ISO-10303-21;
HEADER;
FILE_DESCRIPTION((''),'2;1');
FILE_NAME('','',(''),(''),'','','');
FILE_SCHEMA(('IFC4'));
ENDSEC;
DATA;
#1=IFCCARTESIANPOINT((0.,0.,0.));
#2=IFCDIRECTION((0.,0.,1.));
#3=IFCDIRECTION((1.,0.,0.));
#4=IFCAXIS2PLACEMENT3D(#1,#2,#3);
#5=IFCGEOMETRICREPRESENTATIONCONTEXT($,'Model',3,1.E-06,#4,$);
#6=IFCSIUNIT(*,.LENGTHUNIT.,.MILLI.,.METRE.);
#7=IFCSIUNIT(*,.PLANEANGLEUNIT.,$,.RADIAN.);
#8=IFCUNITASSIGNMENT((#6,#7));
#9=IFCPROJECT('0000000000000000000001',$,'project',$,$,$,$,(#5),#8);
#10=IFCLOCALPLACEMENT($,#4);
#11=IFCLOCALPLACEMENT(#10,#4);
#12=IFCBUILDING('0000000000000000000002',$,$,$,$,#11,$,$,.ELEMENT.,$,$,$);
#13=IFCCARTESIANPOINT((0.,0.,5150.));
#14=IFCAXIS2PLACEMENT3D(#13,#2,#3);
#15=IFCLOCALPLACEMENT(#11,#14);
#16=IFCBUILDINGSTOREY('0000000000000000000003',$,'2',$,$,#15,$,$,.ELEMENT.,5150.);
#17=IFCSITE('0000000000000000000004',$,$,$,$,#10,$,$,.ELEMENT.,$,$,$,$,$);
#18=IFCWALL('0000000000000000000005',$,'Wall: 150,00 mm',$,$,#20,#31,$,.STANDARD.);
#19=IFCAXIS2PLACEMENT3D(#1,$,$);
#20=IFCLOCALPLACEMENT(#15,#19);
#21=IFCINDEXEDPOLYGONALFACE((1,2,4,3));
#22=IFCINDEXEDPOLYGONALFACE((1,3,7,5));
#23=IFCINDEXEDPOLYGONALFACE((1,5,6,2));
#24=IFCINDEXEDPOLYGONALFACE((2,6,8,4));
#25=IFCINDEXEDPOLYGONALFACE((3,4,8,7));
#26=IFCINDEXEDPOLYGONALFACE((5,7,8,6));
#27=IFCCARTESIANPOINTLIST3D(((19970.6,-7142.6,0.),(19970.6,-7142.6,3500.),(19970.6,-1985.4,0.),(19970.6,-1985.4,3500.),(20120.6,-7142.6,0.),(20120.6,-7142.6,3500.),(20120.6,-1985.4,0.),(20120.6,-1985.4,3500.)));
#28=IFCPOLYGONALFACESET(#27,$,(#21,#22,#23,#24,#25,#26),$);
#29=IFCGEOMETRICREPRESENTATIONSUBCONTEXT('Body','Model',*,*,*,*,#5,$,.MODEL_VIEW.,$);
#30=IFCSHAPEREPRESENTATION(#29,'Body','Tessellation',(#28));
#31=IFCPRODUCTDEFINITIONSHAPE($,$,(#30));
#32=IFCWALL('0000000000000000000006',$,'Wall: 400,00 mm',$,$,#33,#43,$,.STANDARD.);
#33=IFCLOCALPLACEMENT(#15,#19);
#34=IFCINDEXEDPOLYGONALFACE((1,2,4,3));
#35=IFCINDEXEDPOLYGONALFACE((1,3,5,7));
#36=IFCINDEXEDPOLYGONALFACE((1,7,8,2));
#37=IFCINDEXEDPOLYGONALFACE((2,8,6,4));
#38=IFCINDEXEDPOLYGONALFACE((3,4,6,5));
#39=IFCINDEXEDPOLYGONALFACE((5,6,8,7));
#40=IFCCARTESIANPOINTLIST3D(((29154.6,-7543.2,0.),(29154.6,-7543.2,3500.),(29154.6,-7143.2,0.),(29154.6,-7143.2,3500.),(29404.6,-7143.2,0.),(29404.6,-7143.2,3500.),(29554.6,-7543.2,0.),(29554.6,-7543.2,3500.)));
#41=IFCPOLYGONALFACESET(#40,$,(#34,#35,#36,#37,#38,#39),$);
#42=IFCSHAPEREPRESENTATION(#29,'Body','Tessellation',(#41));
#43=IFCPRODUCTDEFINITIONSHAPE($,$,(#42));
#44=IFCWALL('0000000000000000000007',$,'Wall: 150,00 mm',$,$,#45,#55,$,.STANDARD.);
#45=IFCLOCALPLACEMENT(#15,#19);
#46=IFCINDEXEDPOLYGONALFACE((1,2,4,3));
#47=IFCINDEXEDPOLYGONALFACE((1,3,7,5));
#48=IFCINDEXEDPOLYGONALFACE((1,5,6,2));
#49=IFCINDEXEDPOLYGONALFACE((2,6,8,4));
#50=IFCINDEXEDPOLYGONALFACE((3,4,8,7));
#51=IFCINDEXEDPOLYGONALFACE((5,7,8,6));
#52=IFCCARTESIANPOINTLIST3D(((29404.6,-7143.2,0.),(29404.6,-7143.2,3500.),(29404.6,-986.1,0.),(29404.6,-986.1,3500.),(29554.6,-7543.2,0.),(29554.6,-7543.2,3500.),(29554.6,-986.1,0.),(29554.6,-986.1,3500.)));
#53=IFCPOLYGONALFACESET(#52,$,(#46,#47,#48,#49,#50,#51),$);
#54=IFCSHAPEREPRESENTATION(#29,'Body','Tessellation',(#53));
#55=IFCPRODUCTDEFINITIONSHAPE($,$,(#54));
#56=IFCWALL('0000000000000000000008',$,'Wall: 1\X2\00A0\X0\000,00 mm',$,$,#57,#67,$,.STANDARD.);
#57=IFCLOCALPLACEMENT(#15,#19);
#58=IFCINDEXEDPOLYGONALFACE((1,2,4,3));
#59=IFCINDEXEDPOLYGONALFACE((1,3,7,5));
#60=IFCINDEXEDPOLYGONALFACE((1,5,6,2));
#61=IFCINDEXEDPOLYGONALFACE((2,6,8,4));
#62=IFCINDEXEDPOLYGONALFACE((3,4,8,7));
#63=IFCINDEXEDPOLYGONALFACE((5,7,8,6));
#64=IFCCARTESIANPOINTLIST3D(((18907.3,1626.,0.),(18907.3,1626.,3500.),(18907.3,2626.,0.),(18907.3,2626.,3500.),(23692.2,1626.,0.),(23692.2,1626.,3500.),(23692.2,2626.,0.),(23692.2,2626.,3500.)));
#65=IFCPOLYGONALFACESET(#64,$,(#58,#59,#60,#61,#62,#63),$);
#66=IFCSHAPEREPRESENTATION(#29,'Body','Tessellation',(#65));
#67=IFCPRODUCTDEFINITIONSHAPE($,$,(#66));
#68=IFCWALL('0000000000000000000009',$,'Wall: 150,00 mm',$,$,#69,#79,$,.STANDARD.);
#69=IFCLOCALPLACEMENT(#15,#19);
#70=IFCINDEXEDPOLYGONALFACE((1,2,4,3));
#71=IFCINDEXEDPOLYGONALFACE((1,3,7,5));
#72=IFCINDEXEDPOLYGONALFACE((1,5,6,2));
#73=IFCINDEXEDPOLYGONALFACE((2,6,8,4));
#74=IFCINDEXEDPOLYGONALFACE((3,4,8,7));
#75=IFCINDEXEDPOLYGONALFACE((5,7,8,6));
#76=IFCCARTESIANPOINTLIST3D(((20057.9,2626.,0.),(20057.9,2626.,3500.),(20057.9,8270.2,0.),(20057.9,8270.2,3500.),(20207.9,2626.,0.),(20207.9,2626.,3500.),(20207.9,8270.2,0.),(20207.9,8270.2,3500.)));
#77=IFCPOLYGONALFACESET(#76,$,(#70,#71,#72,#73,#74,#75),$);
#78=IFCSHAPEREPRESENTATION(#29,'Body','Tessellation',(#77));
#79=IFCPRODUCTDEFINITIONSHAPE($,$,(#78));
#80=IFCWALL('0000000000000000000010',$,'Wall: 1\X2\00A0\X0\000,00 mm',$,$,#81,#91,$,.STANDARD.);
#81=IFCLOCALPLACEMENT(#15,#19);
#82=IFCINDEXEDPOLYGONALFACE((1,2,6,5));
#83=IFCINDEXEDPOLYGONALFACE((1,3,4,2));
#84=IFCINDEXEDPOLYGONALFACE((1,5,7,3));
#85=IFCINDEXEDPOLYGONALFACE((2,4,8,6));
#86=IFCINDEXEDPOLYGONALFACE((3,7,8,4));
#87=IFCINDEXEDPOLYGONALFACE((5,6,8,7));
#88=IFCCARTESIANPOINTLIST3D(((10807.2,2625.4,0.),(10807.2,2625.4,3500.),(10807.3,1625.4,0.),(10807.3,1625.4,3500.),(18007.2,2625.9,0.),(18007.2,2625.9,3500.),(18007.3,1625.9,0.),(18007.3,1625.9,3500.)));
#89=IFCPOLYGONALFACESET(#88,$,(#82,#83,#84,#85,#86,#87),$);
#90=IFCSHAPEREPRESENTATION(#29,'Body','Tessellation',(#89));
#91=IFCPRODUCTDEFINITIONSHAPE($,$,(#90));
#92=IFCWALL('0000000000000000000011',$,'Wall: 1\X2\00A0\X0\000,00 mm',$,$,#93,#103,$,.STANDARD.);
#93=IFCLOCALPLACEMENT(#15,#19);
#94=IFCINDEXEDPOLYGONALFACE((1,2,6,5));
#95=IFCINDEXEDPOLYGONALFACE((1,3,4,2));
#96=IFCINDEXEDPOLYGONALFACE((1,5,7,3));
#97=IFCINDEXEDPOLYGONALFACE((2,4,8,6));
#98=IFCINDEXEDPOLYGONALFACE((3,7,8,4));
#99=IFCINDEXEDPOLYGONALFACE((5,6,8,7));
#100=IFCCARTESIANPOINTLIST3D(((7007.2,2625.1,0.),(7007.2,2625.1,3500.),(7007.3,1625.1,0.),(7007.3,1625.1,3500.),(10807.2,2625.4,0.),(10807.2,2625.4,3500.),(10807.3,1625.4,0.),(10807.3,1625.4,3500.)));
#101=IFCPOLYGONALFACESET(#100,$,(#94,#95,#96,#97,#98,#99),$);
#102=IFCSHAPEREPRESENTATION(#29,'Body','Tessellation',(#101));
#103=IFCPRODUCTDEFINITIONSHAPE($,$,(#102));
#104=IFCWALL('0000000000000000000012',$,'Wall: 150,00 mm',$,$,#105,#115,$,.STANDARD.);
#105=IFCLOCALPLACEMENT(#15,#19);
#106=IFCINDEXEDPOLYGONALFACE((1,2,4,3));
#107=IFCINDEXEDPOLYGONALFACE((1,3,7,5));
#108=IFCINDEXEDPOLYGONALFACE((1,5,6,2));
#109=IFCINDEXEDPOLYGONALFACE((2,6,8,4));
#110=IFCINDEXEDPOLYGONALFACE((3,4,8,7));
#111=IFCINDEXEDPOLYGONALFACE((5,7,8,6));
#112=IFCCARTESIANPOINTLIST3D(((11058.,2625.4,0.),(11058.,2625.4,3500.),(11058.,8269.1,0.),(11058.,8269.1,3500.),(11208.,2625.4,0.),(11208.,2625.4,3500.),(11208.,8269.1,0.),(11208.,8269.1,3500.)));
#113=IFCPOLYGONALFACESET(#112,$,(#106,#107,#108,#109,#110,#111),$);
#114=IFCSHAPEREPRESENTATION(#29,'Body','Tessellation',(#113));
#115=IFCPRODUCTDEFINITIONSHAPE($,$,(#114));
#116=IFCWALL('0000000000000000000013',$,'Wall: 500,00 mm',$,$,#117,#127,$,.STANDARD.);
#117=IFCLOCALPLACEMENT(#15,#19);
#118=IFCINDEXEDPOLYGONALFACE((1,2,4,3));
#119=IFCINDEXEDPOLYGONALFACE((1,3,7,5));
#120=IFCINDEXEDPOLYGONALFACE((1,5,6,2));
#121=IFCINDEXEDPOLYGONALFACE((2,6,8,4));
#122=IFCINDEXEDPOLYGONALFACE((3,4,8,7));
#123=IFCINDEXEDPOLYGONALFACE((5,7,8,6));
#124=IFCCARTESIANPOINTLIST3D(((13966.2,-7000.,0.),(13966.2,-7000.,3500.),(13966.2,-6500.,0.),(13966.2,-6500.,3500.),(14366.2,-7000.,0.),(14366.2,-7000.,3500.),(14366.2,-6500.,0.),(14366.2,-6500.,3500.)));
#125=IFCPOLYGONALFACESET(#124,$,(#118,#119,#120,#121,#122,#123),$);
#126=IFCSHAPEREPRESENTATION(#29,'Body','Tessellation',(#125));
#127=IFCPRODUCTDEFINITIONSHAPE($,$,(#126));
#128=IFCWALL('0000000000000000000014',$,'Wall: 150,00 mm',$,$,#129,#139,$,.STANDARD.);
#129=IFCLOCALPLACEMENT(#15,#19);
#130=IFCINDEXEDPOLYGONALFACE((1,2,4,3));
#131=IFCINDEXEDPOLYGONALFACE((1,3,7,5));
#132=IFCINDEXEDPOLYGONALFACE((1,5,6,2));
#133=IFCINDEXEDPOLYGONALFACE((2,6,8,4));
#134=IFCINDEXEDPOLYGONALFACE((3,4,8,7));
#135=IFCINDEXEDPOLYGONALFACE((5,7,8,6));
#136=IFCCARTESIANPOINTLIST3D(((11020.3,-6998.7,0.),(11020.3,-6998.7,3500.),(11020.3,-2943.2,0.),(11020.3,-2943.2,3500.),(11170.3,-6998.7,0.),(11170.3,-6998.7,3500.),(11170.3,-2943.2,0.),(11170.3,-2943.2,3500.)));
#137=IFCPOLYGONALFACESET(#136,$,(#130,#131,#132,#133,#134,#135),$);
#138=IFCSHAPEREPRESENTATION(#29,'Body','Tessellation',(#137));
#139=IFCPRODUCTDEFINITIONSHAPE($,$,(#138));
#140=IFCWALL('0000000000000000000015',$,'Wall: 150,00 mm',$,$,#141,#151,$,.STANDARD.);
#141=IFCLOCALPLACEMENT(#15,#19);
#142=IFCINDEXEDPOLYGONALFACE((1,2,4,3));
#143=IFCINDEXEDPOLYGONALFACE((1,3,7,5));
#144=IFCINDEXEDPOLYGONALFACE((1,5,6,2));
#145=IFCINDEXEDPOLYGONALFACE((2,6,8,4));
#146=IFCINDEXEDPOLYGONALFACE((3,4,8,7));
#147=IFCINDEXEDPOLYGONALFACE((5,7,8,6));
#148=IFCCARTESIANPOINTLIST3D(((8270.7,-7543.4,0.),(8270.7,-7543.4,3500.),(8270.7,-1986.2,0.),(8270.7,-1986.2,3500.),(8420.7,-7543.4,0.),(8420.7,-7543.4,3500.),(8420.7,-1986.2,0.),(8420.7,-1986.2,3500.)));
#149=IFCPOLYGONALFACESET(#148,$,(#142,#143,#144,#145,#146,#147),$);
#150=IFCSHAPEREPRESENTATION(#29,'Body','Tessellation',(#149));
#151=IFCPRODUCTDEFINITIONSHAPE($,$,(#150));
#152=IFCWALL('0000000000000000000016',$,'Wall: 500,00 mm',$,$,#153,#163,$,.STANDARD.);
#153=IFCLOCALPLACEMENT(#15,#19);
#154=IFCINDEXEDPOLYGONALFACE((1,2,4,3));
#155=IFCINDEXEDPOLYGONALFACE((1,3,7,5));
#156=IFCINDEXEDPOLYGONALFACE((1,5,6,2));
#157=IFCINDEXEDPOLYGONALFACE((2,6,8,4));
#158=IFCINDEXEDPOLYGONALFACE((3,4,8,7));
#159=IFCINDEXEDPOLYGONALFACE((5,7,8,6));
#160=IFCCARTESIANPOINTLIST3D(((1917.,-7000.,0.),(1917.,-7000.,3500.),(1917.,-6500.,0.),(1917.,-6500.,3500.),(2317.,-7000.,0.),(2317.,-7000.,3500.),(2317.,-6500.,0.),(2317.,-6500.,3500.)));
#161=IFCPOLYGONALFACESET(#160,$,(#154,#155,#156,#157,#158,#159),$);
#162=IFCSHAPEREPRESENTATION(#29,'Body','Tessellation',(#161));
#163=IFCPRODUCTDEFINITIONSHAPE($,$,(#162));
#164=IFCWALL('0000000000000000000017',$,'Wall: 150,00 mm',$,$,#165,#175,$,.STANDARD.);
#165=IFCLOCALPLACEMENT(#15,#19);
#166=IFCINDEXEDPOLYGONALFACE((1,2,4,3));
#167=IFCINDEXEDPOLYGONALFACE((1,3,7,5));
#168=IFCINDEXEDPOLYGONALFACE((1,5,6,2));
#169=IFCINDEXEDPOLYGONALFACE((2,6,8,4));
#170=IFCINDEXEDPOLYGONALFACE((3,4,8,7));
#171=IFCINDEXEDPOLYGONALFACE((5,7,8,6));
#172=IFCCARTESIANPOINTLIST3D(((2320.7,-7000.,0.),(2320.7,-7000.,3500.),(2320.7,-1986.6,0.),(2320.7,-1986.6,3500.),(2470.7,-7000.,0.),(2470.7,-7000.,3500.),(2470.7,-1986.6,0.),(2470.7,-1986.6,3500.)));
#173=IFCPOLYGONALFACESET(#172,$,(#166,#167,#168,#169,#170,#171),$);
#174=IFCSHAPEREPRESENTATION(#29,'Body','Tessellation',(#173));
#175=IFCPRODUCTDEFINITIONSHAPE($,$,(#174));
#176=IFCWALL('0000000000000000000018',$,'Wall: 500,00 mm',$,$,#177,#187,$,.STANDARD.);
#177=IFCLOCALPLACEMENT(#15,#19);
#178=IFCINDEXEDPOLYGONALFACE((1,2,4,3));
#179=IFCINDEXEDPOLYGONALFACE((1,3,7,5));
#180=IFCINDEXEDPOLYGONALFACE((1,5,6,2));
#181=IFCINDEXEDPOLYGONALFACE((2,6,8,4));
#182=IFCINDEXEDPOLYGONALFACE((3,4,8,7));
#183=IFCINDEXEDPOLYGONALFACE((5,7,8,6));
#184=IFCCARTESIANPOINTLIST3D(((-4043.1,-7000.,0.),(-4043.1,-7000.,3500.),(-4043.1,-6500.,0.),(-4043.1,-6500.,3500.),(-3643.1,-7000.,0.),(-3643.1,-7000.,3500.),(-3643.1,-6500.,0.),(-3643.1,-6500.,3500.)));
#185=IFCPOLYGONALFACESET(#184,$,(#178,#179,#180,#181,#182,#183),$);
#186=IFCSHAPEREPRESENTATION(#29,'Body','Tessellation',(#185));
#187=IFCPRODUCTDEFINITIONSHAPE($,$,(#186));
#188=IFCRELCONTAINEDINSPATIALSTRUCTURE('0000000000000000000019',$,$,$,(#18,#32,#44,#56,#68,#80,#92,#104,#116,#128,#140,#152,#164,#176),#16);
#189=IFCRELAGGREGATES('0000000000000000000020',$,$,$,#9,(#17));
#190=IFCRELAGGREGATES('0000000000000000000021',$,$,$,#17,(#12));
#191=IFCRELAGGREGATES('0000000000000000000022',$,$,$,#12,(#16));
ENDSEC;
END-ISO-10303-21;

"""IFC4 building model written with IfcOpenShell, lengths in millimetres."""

from ifc_helpers import new_model, si_unit, frame, origin_with_axes, place, context, subcontext, project, spatial, line, indexed_curve, outline, extrude, element, save


model = new_model("IFC4")

# Units and contexts
model_context = context("Model", 3, precision=1e-06, world=origin_with_axes())
body_context = subcontext(model_context, "Body", "Model", "MODEL_VIEW")
ifc_project = project(units=[si_unit("LENGTHUNIT", "METRE", prefix="MILLI"), si_unit("PLANEANGLEUNIT", "RADIAN")], contexts=[model_context])

# Site, building, storey
site_placement = place(None, origin_with_axes())
site = spatial("IfcSite", under=ifc_project, at=site_placement, CompositionType="ELEMENT")
building_placement = place(site_placement, origin_with_axes())
building = spatial("IfcBuilding", under=site, at=building_placement, CompositionType="ELEMENT")
storey_placement = place(building_placement, frame((0.0, 0.0, 5150.0), z_axis=(0.0, 0.0, 1.0), x_axis=(1.0, 0.0, 0.0)))
storey = spatial("IfcBuildingStorey", under=building, at=storey_placement, Name="2", CompositionType="ELEMENT", Elevation=5150.0)

# Walls
wall_1_placement = place(storey_placement, frame((20120.6, -7142.6, 0.0), z_axis=(0.0, 0.0, 1.0), x_axis=(0.0, 1.0, 0.0)))
element("IfcWall", 1, at=wall_1_placement, inside=storey, Name="Wall: 150,00 mm", PredefinedType="STANDARD", context=body_context, shape_type="SweptSolid", body=[
    extrude(outline(indexed_curve([(0.0, 0.0), (5157.2, 0.0), (5157.2, 150.0), (0.0, 150.0)], segments=[line(1, 2), line(2, 3), line(3, 4), line(4, 1)])), origin_with_axes(), (0.0, 0.0, 1.0), 3500.0),
])
wall_2_placement = place(storey_placement, frame((29154.6, -7143.2, 0.0), z_axis=(0.0, 0.0, 1.0), x_axis=(1.0, 0.000069, 0.0)))
element("IfcWall", 2, at=wall_2_placement, inside=storey, Name="Wall: 400,00 mm", PredefinedType="STANDARD", context=body_context, shape_type="SweptSolid", body=[
    extrude(outline(indexed_curve([(0.0, -400.0), (400.0, -400.0), (250.0, 0.0), (0.0, 0.0)], segments=[line(1, 2), line(2, 3), line(3, 4), line(4, 1)])), origin_with_axes(), (0.0, 0.0, 1.0), 3500.0),
])
wall_3_placement = place(storey_placement, frame((29404.6, -7143.2, 0.0), z_axis=(0.0, 0.0, 1.0), x_axis=(0.0, 1.0, 0.0)))
element("IfcWall", 3, at=wall_3_placement, inside=storey, Name="Wall: 150,00 mm", PredefinedType="STANDARD", context=body_context, shape_type="SweptSolid", body=[
    extrude(outline(indexed_curve([(-400.0, -150.0), (6157.0, -150.0), (6157.0, 0.0), (0.0, 0.0)], segments=[line(1, 2), line(2, 3), line(3, 4), line(4, 1)])), origin_with_axes(), (0.0, 0.0, 1.0), 3500.0),
])
wall_4_placement = place(storey_placement, frame((23692.2, 1626.0, 0.0), z_axis=(0.0, 0.0, 1.0), x_axis=(-1.0, 0.0, 0.0)))
element("IfcWall", 4, at=wall_4_placement, inside=storey, Name="Wall: 1 000,00 mm", PredefinedType="STANDARD", context=body_context, shape_type="SweptSolid", body=[
    extrude(outline(indexed_curve([(0.0, -1000.0), (4784.9, -1000.0), (4784.9, 0.0), (0.0, 0.0)], segments=[line(1, 2), line(2, 3), line(3, 4), line(4, 1)])), origin_with_axes(), (0.0, 0.0, 1.0), 3500.0),
])
wall_5_placement = place(storey_placement, frame((20207.9, 2626.0, 0.0), z_axis=(0.0, 0.0, 1.0), x_axis=(0.0, 1.0, 0.0)))
element("IfcWall", 5, at=wall_5_placement, inside=storey, Name="Wall: 150,00 mm", PredefinedType="STANDARD", context=body_context, shape_type="SweptSolid", body=[
    extrude(outline(indexed_curve([(0.0, 0.0), (5644.1, 0.0), (5644.1, 150.0), (0.0, 150.0)], segments=[line(1, 2), line(2, 3), line(3, 4), line(4, 1)])), origin_with_axes(), (0.0, 0.0, 1.0), 3500.0),
])
wall_6_placement = place(storey_placement, frame((18007.3, 1625.9, 0.0), z_axis=(0.0, 0.0, 1.0), x_axis=(-1.0, -0.000069, 0.0)))
element("IfcWall", 6, at=wall_6_placement, inside=storey, Name="Wall: 1 000,00 mm", PredefinedType="STANDARD", context=body_context, shape_type="SweptSolid", body=[
    extrude(outline(indexed_curve([(0.0, -1000.0), (7200.0, -1000.0), (7200.0, 0.0), (0.0, 0.0)], segments=[line(1, 2), line(2, 3), line(3, 4), line(4, 1)])), origin_with_axes(), (0.0, 0.0, 1.0), 3500.0),
])
wall_7_placement = place(storey_placement, frame((10807.3, 1625.4, 0.0), z_axis=(0.0, 0.0, 1.0), x_axis=(-1.0, -0.000069, 0.0)))
element("IfcWall", 7, at=wall_7_placement, inside=storey, Name="Wall: 1 000,00 mm", PredefinedType="STANDARD", context=body_context, shape_type="SweptSolid", body=[
    extrude(outline(indexed_curve([(0.0, -1000.0), (3800.0, -1000.0), (3800.0, 0.0), (0.0, 0.0)], segments=[line(1, 2), line(2, 3), line(3, 4), line(4, 1)])), origin_with_axes(), (0.0, 0.0, 1.0), 3500.0),
])
wall_8_placement = place(storey_placement, frame((11208.0, 2625.4, 0.0), z_axis=(0.0, 0.0, 1.0), x_axis=(0.0, 1.0, 0.0)))
element("IfcWall", 8, at=wall_8_placement, inside=storey, Name="Wall: 150,00 mm", PredefinedType="STANDARD", context=body_context, shape_type="SweptSolid", body=[
    extrude(outline(indexed_curve([(0.0, 0.0), (5643.7, 0.0), (5643.7, 150.0), (0.0, 150.0)], segments=[line(1, 2), line(2, 3), line(3, 4), line(4, 1)])), origin_with_axes(), (0.0, 0.0, 1.0), 3500.0),
])
wall_9_placement = place(storey_placement, frame((13966.2, -7000.0, 0.0), z_axis=(0.0, 0.0, 1.0), x_axis=(1.0, 0.000069, 0.0)))
element("IfcWall", 9, at=wall_9_placement, inside=storey, Name="Wall: 500,00 mm", PredefinedType="STANDARD", context=body_context, shape_type="SweptSolid", body=[
    extrude(outline(indexed_curve([(0.0, 0.0), (400.0, 0.0), (400.0, 500.0), (0.0, 500.0)], segments=[line(1, 2), line(2, 3), line(3, 4), line(4, 1)])), origin_with_axes(), (0.0, 0.0, 1.0), 3500.0),
])
wall_10_placement = place(storey_placement, frame((11170.3, -6998.7, 0.0), z_axis=(0.0, 0.0, 1.0), x_axis=(0.0, 1.0, 0.0)))
element("IfcWall", 10, at=wall_10_placement, inside=storey, Name="Wall: 150,00 mm", PredefinedType="STANDARD", context=body_context, shape_type="SweptSolid", body=[
    extrude(outline(indexed_curve([(0.0, 0.0), (4055.5, 0.0), (4055.5, 150.0), (0.0, 150.0)], segments=[line(1, 2), line(2, 3), line(3, 4), line(4, 1)])), origin_with_axes(), (0.0, 0.0, 1.0), 3500.0),
])
wall_11_placement = place(storey_placement, frame((8420.7, -7543.4, 0.0), z_axis=(0.0, 0.0, 1.0), x_axis=(0.0, 1.0, 0.0)))
element("IfcWall", 11, at=wall_11_placement, inside=storey, Name="Wall: 150,00 mm", PredefinedType="STANDARD", context=body_context, shape_type="SweptSolid", body=[
    extrude(outline(indexed_curve([(0.0, 0.0), (5557.2, 0.0), (5557.2, 150.0), (0.0, 150.0)], segments=[line(1, 2), line(2, 3), line(3, 4), line(4, 1)])), origin_with_axes(), (0.0, 0.0, 1.0), 3500.0),
])
wall_12_placement = place(storey_placement, frame((1917.0, -7000.0, 0.0), z_axis=(0.0, 0.0, 1.0), x_axis=(1.0, 0.000069, 0.0)))
element("IfcWall", 12, at=wall_12_placement, inside=storey, Name="Wall: 500,00 mm", PredefinedType="STANDARD", context=body_context, shape_type="SweptSolid", body=[
    extrude(outline(indexed_curve([(0.0, 0.0), (400.0, 0.0), (400.0, 500.0), (0.0, 500.0)], segments=[line(1, 2), line(2, 3), line(3, 4), line(4, 1)])), origin_with_axes(), (0.0, 0.0, 1.0), 3500.0),
])
wall_13_placement = place(storey_placement, frame((2320.7, -7000.0, 0.0), z_axis=(0.0, 0.0, 1.0), x_axis=(0.0, 1.0, 0.0)))
element("IfcWall", 13, at=wall_13_placement, inside=storey, Name="Wall: 150,00 mm", PredefinedType="STANDARD", context=body_context, shape_type="SweptSolid", body=[
    extrude(outline(indexed_curve([(0.0, -150.0), (5013.4, -150.0), (5013.4, 0.0), (0.0, 0.0)], segments=[line(1, 2), line(2, 3), line(3, 4), line(4, 1)])), origin_with_axes(), (0.0, 0.0, 1.0), 3500.0),
])
wall_14_placement = place(storey_placement, frame((-4043.1, -7000.0, 0.0), z_axis=(0.0, 0.0, 1.0), x_axis=(1.0, 0.000069, 0.0)))
element("IfcWall", 14, at=wall_14_placement, inside=storey, Name="Wall: 500,00 mm", PredefinedType="STANDARD", context=body_context, shape_type="SweptSolid", body=[
    extrude(outline(indexed_curve([(0.0, 0.0), (400.0, 0.0), (400.0, 500.0), (0.0, 500.0)], segments=[line(1, 2), line(2, 3), line(3, 4), line(4, 1)])), origin_with_axes(), (0.0, 0.0, 1.0), 3500.0),
])

save(model, "model.ifc")
